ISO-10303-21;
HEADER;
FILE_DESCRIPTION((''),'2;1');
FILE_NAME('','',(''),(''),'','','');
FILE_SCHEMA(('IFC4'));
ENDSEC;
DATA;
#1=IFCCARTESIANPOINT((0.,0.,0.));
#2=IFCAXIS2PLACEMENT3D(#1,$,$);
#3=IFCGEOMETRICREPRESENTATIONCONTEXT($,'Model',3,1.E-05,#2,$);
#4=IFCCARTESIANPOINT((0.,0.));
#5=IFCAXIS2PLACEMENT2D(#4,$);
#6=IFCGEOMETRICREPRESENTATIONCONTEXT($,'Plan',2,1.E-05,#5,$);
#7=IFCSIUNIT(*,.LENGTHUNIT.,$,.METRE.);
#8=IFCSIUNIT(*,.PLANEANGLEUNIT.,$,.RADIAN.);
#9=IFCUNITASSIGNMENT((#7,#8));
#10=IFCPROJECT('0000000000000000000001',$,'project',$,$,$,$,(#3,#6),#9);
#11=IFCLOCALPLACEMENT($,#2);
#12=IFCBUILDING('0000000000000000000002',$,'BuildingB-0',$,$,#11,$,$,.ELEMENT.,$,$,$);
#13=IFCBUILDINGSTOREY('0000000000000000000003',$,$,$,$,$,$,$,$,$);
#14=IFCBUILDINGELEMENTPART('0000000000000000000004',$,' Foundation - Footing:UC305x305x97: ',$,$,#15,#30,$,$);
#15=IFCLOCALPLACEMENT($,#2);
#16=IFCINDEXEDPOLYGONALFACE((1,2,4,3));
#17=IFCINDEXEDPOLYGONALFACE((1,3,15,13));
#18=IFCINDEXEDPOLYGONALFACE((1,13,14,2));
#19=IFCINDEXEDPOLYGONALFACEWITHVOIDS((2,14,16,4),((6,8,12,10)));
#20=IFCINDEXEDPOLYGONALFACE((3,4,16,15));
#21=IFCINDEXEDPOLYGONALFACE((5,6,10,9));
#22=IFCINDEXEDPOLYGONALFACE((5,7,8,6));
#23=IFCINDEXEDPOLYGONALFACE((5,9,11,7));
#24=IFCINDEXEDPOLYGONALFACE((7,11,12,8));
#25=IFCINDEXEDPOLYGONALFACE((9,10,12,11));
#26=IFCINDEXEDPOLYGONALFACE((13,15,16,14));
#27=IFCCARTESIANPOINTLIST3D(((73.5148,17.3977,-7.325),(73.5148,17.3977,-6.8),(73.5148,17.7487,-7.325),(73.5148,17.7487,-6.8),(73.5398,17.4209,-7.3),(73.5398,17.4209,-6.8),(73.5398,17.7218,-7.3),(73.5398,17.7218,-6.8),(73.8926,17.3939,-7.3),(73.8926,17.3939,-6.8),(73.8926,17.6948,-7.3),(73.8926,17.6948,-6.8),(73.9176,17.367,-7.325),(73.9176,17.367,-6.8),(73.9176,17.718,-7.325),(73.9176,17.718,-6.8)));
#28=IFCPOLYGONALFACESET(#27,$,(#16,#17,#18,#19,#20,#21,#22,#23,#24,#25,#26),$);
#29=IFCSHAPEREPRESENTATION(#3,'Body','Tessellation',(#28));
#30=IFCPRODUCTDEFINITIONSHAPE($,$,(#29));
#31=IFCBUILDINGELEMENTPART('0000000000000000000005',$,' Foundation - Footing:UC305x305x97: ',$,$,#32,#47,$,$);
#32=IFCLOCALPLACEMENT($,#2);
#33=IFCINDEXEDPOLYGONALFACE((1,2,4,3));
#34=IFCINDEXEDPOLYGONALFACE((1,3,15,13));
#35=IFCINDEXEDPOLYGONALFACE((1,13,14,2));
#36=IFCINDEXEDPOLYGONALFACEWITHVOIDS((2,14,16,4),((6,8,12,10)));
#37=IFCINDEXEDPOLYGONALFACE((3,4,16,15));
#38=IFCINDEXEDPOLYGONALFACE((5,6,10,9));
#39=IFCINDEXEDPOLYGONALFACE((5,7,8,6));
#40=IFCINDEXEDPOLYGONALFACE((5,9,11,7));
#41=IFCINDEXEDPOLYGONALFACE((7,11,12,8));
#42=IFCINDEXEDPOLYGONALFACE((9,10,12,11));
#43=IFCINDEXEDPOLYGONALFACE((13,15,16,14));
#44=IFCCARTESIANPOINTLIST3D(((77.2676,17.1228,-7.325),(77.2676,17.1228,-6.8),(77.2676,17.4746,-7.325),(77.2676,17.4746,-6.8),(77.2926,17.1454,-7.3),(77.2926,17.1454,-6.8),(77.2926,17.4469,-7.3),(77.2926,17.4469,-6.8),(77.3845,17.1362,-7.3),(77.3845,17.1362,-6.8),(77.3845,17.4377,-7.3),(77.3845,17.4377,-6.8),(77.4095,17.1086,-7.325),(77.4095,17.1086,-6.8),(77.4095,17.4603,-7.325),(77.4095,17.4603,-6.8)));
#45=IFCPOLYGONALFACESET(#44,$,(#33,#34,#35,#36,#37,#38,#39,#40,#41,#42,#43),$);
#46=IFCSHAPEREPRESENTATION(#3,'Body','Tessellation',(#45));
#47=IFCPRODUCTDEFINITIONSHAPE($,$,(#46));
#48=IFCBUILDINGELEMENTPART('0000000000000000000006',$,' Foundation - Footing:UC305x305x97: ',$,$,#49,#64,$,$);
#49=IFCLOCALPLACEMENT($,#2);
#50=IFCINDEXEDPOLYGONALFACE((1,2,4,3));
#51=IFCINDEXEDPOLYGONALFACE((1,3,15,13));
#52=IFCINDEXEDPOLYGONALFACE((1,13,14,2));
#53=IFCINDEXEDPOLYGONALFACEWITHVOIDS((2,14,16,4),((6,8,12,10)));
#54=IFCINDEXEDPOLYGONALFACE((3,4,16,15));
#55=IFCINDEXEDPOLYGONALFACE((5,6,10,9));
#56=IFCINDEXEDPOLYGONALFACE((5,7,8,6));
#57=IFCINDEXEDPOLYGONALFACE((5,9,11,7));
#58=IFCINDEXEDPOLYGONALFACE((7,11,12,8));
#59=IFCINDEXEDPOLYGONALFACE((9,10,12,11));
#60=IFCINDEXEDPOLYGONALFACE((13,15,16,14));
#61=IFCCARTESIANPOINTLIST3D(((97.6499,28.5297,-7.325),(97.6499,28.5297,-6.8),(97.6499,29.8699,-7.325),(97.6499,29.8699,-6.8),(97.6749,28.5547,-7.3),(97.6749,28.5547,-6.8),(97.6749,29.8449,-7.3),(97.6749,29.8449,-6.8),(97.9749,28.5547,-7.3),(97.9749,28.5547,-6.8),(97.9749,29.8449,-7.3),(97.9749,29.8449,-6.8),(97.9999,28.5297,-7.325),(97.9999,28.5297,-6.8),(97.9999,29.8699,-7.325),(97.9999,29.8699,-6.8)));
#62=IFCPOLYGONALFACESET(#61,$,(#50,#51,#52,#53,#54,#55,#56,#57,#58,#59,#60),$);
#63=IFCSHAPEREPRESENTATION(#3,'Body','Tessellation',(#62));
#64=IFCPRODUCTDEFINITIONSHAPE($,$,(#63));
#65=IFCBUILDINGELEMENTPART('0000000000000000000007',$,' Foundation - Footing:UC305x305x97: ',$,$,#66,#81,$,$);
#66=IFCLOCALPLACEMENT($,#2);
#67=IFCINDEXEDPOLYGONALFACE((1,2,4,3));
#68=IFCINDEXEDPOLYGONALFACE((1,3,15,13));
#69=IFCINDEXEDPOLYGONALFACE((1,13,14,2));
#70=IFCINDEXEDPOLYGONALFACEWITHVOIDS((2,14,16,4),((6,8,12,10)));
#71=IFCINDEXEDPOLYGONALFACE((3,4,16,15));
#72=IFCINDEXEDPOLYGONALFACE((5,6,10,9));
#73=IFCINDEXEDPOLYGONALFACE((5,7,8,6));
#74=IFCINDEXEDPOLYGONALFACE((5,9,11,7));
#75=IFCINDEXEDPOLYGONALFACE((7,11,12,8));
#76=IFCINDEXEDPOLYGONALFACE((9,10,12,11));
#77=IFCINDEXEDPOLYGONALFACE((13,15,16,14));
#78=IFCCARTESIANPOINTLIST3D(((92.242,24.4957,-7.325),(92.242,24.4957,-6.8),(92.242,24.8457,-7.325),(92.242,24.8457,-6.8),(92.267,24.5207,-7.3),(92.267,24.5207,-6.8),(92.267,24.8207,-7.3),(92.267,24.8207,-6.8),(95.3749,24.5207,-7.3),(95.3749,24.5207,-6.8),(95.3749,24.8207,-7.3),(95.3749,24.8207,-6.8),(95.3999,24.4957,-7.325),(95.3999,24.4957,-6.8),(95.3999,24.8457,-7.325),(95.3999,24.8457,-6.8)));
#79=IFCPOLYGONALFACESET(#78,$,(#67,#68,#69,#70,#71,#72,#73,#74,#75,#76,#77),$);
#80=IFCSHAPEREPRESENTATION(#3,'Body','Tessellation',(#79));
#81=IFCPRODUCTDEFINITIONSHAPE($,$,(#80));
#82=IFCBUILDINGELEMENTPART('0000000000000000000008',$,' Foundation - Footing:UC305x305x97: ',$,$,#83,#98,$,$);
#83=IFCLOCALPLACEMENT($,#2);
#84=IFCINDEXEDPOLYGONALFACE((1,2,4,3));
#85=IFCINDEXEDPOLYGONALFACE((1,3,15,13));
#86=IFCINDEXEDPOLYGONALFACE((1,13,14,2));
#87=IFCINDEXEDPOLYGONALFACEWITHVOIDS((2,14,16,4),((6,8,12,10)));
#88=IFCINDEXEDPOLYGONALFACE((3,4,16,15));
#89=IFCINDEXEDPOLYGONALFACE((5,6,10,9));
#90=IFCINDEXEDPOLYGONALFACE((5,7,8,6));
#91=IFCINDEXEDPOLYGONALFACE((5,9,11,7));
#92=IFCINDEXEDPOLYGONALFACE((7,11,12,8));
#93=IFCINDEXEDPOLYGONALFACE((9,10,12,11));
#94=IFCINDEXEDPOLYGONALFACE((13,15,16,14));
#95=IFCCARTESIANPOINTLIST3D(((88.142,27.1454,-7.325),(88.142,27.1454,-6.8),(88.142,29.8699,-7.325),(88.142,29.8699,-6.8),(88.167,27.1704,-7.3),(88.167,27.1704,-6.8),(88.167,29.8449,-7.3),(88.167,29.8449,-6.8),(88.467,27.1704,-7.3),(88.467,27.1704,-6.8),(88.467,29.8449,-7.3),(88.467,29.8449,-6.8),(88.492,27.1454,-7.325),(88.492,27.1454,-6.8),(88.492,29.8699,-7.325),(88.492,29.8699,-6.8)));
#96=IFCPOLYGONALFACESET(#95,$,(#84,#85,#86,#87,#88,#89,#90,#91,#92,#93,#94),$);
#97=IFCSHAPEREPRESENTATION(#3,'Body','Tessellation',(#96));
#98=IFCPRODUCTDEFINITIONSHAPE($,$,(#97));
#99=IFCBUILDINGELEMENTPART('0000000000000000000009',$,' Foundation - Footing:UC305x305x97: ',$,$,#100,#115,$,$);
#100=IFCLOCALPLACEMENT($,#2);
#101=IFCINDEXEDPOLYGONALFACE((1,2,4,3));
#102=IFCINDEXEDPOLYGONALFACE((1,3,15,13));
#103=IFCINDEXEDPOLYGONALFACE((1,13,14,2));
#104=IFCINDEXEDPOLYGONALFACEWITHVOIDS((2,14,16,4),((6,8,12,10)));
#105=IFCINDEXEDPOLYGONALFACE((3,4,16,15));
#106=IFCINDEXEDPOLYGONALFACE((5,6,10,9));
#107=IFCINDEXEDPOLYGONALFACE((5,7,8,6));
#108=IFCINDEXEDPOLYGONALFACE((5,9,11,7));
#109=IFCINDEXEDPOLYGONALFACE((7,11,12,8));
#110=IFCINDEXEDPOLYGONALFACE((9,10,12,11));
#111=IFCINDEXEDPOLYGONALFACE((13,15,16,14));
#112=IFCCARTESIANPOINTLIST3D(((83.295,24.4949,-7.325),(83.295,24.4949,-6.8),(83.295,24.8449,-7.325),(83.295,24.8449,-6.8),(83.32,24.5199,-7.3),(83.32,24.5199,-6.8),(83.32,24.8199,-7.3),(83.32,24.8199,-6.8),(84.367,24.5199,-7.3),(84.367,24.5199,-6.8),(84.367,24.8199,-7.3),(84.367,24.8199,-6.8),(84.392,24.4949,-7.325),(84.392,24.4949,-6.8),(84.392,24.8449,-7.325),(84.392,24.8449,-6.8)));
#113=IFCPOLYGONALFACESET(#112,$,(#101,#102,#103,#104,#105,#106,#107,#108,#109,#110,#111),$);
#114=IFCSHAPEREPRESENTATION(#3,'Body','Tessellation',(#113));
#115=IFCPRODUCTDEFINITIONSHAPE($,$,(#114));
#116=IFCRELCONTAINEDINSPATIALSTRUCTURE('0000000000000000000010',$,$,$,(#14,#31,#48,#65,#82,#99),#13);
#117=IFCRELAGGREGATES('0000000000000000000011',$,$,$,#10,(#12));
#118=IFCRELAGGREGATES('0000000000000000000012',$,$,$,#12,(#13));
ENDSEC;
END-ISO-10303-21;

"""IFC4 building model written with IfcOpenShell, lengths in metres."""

from ifc_helpers import new_model, si_unit, origin, origin_2d, place, context, project, spatial, polyline, outline, extrude, element, save


model = new_model("IFC4")

# Units and contexts
model_context = context("Model", 3, precision=1e-05, world=origin())
plan_context = context("Plan", 2, precision=1e-05, world=origin_2d())
ifc_project = project(units=[si_unit("LENGTHUNIT", "METRE"), si_unit("PLANEANGLEUNIT", "RADIAN")], contexts=[model_context, plan_context])

# Building, storey
building_placement = place(None, origin())
building = spatial("IfcBuilding", under=ifc_project, at=building_placement, Name="BuildingB-0", CompositionType="ELEMENT")
storey = spatial("IfcBuildingStorey", under=building)

# Building element parts, openings
building_element_part_1 = element("IfcBuildingElementPart", 1, inside=storey, Name=" Foundation - Footing:UC305x305x97: ", context=model_context, shape_type="SweptSolid", body=[
    extrude(outline(polyline([(73.9176, 17.367, -7.325), (73.5148, 17.3977, -7.325), (73.5148, 17.7487, -7.325), (73.9176, 17.718, -7.325), (73.9176, 17.367, -7.325)])), None, (0.0, 0.0, 1.0), 0.525),
])
element("IfcOpeningElement", 2, inside=storey, cuts=building_element_part_1, context=model_context, shape_type="SweptSolid", body=[
    extrude(outline(polyline([(73.8926, 17.3939, -7.3), (73.5398, 17.4209, -7.3), (73.5398, 17.7218, -7.3), (73.8926, 17.6948, -7.3), (73.8926, 17.3939, -7.3)])), None, (0.0, 0.0, 1.0), 0.5),
])
building_element_part_2 = element("IfcBuildingElementPart", 3, inside=storey, Name=" Foundation - Footing:UC305x305x97: ", context=model_context, shape_type="SweptSolid", body=[
    extrude(outline(polyline([(77.4095, 17.1086, -7.325), (77.2676, 17.1228, -7.325), (77.2676, 17.4746, -7.325), (77.4095, 17.4603, -7.325), (77.4095, 17.1086, -7.325)])), None, (0.0, 0.0, 1.0), 0.525),
])
element("IfcOpeningElement", 4, inside=storey, cuts=building_element_part_2, context=model_context, shape_type="SweptSolid", body=[
    extrude(outline(polyline([(77.3845, 17.1362, -7.3), (77.2926, 17.1454, -7.3), (77.2926, 17.4469, -7.3), (77.3845, 17.4377, -7.3), (77.3845, 17.1362, -7.3)])), None, (0.0, 0.0, 1.0), 0.5),
])
building_element_part_3 = element("IfcBuildingElementPart", 5, inside=storey, Name=" Foundation - Footing:UC305x305x97: ", context=model_context, shape_type="SweptSolid", body=[
    extrude(outline(polyline([(97.9999, 28.5297, -7.325), (97.6499, 28.5297, -7.325), (97.6499, 29.8699, -7.325), (97.9999, 29.8699, -7.325), (97.9999, 28.5297, -7.325)])), None, (0.0, 0.0, 1.0), 0.525),
])
element("IfcOpeningElement", 6, inside=storey, cuts=building_element_part_3, context=model_context, shape_type="SweptSolid", body=[
    extrude(outline(polyline([(97.9749, 28.5547, -7.3), (97.6749, 28.5547, -7.3), (97.6749, 29.8449, -7.3), (97.9749, 29.8449, -7.3), (97.9749, 28.5547, -7.3)])), None, (0.0, 0.0, 1.0), 0.5),
])
building_element_part_4 = element("IfcBuildingElementPart", 7, inside=storey, Name=" Foundation - Footing:UC305x305x97: ", context=model_context, shape_type="SweptSolid", body=[
    extrude(outline(polyline([(95.3999, 24.4957, -7.325), (95.3999, 24.8457, -7.325), (92.242, 24.8457, -7.325), (92.242, 24.4957, -7.325), (95.3999, 24.4957, -7.325)])), None, (0.0, 0.0, 1.0), 0.525),
])
element("IfcOpeningElement", 8, inside=storey, cuts=building_element_part_4, context=model_context, shape_type="SweptSolid", body=[
    extrude(outline(polyline([(95.3749, 24.5207, -7.3), (95.3749, 24.8207, -7.3), (92.267, 24.8207, -7.3), (92.267, 24.5207, -7.3), (95.3749, 24.5207, -7.3)])), None, (0.0, 0.0, 1.0), 0.5),
])
building_element_part_5 = element("IfcBuildingElementPart", 9, inside=storey, Name=" Foundation - Footing:UC305x305x97: ", context=model_context, shape_type="SweptSolid", body=[
    extrude(outline(polyline([(88.492, 27.1454, -7.325), (88.142, 27.1454, -7.325), (88.142, 29.8699, -7.325), (88.492, 29.8699, -7.325), (88.492, 27.1454, -7.325)])), None, (0.0, 0.0, 1.0), 0.525),
])
element("IfcOpeningElement", 10, inside=storey, cuts=building_element_part_5, context=model_context, shape_type="SweptSolid", body=[
    extrude(outline(polyline([(88.467, 27.1704, -7.3), (88.167, 27.1704, -7.3), (88.167, 29.8449, -7.3), (88.467, 29.8449, -7.3), (88.467, 27.1704, -7.3)])), None, (0.0, 0.0, 1.0), 0.5),
])
building_element_part_6 = element("IfcBuildingElementPart", 11, inside=storey, Name=" Foundation - Footing:UC305x305x97: ", context=model_context, shape_type="SweptSolid", body=[
    extrude(outline(polyline([(84.392, 24.4949, -7.325), (84.392, 24.8449, -7.325), (83.295, 24.8449, -7.325), (83.295, 24.4949, -7.325), (84.392, 24.4949, -7.325)])), None, (0.0, 0.0, 1.0), 0.525),
])
element("IfcOpeningElement", 12, inside=storey, cuts=building_element_part_6, context=model_context, shape_type="SweptSolid", body=[
    extrude(outline(polyline([(84.367, 24.5199, -7.3), (84.367, 24.8199, -7.3), (83.32, 24.8199, -7.3), (83.32, 24.5199, -7.3), (84.367, 24.5199, -7.3)])), None, (0.0, 0.0, 1.0), 0.5),
])

save(model, "model.ifc")
